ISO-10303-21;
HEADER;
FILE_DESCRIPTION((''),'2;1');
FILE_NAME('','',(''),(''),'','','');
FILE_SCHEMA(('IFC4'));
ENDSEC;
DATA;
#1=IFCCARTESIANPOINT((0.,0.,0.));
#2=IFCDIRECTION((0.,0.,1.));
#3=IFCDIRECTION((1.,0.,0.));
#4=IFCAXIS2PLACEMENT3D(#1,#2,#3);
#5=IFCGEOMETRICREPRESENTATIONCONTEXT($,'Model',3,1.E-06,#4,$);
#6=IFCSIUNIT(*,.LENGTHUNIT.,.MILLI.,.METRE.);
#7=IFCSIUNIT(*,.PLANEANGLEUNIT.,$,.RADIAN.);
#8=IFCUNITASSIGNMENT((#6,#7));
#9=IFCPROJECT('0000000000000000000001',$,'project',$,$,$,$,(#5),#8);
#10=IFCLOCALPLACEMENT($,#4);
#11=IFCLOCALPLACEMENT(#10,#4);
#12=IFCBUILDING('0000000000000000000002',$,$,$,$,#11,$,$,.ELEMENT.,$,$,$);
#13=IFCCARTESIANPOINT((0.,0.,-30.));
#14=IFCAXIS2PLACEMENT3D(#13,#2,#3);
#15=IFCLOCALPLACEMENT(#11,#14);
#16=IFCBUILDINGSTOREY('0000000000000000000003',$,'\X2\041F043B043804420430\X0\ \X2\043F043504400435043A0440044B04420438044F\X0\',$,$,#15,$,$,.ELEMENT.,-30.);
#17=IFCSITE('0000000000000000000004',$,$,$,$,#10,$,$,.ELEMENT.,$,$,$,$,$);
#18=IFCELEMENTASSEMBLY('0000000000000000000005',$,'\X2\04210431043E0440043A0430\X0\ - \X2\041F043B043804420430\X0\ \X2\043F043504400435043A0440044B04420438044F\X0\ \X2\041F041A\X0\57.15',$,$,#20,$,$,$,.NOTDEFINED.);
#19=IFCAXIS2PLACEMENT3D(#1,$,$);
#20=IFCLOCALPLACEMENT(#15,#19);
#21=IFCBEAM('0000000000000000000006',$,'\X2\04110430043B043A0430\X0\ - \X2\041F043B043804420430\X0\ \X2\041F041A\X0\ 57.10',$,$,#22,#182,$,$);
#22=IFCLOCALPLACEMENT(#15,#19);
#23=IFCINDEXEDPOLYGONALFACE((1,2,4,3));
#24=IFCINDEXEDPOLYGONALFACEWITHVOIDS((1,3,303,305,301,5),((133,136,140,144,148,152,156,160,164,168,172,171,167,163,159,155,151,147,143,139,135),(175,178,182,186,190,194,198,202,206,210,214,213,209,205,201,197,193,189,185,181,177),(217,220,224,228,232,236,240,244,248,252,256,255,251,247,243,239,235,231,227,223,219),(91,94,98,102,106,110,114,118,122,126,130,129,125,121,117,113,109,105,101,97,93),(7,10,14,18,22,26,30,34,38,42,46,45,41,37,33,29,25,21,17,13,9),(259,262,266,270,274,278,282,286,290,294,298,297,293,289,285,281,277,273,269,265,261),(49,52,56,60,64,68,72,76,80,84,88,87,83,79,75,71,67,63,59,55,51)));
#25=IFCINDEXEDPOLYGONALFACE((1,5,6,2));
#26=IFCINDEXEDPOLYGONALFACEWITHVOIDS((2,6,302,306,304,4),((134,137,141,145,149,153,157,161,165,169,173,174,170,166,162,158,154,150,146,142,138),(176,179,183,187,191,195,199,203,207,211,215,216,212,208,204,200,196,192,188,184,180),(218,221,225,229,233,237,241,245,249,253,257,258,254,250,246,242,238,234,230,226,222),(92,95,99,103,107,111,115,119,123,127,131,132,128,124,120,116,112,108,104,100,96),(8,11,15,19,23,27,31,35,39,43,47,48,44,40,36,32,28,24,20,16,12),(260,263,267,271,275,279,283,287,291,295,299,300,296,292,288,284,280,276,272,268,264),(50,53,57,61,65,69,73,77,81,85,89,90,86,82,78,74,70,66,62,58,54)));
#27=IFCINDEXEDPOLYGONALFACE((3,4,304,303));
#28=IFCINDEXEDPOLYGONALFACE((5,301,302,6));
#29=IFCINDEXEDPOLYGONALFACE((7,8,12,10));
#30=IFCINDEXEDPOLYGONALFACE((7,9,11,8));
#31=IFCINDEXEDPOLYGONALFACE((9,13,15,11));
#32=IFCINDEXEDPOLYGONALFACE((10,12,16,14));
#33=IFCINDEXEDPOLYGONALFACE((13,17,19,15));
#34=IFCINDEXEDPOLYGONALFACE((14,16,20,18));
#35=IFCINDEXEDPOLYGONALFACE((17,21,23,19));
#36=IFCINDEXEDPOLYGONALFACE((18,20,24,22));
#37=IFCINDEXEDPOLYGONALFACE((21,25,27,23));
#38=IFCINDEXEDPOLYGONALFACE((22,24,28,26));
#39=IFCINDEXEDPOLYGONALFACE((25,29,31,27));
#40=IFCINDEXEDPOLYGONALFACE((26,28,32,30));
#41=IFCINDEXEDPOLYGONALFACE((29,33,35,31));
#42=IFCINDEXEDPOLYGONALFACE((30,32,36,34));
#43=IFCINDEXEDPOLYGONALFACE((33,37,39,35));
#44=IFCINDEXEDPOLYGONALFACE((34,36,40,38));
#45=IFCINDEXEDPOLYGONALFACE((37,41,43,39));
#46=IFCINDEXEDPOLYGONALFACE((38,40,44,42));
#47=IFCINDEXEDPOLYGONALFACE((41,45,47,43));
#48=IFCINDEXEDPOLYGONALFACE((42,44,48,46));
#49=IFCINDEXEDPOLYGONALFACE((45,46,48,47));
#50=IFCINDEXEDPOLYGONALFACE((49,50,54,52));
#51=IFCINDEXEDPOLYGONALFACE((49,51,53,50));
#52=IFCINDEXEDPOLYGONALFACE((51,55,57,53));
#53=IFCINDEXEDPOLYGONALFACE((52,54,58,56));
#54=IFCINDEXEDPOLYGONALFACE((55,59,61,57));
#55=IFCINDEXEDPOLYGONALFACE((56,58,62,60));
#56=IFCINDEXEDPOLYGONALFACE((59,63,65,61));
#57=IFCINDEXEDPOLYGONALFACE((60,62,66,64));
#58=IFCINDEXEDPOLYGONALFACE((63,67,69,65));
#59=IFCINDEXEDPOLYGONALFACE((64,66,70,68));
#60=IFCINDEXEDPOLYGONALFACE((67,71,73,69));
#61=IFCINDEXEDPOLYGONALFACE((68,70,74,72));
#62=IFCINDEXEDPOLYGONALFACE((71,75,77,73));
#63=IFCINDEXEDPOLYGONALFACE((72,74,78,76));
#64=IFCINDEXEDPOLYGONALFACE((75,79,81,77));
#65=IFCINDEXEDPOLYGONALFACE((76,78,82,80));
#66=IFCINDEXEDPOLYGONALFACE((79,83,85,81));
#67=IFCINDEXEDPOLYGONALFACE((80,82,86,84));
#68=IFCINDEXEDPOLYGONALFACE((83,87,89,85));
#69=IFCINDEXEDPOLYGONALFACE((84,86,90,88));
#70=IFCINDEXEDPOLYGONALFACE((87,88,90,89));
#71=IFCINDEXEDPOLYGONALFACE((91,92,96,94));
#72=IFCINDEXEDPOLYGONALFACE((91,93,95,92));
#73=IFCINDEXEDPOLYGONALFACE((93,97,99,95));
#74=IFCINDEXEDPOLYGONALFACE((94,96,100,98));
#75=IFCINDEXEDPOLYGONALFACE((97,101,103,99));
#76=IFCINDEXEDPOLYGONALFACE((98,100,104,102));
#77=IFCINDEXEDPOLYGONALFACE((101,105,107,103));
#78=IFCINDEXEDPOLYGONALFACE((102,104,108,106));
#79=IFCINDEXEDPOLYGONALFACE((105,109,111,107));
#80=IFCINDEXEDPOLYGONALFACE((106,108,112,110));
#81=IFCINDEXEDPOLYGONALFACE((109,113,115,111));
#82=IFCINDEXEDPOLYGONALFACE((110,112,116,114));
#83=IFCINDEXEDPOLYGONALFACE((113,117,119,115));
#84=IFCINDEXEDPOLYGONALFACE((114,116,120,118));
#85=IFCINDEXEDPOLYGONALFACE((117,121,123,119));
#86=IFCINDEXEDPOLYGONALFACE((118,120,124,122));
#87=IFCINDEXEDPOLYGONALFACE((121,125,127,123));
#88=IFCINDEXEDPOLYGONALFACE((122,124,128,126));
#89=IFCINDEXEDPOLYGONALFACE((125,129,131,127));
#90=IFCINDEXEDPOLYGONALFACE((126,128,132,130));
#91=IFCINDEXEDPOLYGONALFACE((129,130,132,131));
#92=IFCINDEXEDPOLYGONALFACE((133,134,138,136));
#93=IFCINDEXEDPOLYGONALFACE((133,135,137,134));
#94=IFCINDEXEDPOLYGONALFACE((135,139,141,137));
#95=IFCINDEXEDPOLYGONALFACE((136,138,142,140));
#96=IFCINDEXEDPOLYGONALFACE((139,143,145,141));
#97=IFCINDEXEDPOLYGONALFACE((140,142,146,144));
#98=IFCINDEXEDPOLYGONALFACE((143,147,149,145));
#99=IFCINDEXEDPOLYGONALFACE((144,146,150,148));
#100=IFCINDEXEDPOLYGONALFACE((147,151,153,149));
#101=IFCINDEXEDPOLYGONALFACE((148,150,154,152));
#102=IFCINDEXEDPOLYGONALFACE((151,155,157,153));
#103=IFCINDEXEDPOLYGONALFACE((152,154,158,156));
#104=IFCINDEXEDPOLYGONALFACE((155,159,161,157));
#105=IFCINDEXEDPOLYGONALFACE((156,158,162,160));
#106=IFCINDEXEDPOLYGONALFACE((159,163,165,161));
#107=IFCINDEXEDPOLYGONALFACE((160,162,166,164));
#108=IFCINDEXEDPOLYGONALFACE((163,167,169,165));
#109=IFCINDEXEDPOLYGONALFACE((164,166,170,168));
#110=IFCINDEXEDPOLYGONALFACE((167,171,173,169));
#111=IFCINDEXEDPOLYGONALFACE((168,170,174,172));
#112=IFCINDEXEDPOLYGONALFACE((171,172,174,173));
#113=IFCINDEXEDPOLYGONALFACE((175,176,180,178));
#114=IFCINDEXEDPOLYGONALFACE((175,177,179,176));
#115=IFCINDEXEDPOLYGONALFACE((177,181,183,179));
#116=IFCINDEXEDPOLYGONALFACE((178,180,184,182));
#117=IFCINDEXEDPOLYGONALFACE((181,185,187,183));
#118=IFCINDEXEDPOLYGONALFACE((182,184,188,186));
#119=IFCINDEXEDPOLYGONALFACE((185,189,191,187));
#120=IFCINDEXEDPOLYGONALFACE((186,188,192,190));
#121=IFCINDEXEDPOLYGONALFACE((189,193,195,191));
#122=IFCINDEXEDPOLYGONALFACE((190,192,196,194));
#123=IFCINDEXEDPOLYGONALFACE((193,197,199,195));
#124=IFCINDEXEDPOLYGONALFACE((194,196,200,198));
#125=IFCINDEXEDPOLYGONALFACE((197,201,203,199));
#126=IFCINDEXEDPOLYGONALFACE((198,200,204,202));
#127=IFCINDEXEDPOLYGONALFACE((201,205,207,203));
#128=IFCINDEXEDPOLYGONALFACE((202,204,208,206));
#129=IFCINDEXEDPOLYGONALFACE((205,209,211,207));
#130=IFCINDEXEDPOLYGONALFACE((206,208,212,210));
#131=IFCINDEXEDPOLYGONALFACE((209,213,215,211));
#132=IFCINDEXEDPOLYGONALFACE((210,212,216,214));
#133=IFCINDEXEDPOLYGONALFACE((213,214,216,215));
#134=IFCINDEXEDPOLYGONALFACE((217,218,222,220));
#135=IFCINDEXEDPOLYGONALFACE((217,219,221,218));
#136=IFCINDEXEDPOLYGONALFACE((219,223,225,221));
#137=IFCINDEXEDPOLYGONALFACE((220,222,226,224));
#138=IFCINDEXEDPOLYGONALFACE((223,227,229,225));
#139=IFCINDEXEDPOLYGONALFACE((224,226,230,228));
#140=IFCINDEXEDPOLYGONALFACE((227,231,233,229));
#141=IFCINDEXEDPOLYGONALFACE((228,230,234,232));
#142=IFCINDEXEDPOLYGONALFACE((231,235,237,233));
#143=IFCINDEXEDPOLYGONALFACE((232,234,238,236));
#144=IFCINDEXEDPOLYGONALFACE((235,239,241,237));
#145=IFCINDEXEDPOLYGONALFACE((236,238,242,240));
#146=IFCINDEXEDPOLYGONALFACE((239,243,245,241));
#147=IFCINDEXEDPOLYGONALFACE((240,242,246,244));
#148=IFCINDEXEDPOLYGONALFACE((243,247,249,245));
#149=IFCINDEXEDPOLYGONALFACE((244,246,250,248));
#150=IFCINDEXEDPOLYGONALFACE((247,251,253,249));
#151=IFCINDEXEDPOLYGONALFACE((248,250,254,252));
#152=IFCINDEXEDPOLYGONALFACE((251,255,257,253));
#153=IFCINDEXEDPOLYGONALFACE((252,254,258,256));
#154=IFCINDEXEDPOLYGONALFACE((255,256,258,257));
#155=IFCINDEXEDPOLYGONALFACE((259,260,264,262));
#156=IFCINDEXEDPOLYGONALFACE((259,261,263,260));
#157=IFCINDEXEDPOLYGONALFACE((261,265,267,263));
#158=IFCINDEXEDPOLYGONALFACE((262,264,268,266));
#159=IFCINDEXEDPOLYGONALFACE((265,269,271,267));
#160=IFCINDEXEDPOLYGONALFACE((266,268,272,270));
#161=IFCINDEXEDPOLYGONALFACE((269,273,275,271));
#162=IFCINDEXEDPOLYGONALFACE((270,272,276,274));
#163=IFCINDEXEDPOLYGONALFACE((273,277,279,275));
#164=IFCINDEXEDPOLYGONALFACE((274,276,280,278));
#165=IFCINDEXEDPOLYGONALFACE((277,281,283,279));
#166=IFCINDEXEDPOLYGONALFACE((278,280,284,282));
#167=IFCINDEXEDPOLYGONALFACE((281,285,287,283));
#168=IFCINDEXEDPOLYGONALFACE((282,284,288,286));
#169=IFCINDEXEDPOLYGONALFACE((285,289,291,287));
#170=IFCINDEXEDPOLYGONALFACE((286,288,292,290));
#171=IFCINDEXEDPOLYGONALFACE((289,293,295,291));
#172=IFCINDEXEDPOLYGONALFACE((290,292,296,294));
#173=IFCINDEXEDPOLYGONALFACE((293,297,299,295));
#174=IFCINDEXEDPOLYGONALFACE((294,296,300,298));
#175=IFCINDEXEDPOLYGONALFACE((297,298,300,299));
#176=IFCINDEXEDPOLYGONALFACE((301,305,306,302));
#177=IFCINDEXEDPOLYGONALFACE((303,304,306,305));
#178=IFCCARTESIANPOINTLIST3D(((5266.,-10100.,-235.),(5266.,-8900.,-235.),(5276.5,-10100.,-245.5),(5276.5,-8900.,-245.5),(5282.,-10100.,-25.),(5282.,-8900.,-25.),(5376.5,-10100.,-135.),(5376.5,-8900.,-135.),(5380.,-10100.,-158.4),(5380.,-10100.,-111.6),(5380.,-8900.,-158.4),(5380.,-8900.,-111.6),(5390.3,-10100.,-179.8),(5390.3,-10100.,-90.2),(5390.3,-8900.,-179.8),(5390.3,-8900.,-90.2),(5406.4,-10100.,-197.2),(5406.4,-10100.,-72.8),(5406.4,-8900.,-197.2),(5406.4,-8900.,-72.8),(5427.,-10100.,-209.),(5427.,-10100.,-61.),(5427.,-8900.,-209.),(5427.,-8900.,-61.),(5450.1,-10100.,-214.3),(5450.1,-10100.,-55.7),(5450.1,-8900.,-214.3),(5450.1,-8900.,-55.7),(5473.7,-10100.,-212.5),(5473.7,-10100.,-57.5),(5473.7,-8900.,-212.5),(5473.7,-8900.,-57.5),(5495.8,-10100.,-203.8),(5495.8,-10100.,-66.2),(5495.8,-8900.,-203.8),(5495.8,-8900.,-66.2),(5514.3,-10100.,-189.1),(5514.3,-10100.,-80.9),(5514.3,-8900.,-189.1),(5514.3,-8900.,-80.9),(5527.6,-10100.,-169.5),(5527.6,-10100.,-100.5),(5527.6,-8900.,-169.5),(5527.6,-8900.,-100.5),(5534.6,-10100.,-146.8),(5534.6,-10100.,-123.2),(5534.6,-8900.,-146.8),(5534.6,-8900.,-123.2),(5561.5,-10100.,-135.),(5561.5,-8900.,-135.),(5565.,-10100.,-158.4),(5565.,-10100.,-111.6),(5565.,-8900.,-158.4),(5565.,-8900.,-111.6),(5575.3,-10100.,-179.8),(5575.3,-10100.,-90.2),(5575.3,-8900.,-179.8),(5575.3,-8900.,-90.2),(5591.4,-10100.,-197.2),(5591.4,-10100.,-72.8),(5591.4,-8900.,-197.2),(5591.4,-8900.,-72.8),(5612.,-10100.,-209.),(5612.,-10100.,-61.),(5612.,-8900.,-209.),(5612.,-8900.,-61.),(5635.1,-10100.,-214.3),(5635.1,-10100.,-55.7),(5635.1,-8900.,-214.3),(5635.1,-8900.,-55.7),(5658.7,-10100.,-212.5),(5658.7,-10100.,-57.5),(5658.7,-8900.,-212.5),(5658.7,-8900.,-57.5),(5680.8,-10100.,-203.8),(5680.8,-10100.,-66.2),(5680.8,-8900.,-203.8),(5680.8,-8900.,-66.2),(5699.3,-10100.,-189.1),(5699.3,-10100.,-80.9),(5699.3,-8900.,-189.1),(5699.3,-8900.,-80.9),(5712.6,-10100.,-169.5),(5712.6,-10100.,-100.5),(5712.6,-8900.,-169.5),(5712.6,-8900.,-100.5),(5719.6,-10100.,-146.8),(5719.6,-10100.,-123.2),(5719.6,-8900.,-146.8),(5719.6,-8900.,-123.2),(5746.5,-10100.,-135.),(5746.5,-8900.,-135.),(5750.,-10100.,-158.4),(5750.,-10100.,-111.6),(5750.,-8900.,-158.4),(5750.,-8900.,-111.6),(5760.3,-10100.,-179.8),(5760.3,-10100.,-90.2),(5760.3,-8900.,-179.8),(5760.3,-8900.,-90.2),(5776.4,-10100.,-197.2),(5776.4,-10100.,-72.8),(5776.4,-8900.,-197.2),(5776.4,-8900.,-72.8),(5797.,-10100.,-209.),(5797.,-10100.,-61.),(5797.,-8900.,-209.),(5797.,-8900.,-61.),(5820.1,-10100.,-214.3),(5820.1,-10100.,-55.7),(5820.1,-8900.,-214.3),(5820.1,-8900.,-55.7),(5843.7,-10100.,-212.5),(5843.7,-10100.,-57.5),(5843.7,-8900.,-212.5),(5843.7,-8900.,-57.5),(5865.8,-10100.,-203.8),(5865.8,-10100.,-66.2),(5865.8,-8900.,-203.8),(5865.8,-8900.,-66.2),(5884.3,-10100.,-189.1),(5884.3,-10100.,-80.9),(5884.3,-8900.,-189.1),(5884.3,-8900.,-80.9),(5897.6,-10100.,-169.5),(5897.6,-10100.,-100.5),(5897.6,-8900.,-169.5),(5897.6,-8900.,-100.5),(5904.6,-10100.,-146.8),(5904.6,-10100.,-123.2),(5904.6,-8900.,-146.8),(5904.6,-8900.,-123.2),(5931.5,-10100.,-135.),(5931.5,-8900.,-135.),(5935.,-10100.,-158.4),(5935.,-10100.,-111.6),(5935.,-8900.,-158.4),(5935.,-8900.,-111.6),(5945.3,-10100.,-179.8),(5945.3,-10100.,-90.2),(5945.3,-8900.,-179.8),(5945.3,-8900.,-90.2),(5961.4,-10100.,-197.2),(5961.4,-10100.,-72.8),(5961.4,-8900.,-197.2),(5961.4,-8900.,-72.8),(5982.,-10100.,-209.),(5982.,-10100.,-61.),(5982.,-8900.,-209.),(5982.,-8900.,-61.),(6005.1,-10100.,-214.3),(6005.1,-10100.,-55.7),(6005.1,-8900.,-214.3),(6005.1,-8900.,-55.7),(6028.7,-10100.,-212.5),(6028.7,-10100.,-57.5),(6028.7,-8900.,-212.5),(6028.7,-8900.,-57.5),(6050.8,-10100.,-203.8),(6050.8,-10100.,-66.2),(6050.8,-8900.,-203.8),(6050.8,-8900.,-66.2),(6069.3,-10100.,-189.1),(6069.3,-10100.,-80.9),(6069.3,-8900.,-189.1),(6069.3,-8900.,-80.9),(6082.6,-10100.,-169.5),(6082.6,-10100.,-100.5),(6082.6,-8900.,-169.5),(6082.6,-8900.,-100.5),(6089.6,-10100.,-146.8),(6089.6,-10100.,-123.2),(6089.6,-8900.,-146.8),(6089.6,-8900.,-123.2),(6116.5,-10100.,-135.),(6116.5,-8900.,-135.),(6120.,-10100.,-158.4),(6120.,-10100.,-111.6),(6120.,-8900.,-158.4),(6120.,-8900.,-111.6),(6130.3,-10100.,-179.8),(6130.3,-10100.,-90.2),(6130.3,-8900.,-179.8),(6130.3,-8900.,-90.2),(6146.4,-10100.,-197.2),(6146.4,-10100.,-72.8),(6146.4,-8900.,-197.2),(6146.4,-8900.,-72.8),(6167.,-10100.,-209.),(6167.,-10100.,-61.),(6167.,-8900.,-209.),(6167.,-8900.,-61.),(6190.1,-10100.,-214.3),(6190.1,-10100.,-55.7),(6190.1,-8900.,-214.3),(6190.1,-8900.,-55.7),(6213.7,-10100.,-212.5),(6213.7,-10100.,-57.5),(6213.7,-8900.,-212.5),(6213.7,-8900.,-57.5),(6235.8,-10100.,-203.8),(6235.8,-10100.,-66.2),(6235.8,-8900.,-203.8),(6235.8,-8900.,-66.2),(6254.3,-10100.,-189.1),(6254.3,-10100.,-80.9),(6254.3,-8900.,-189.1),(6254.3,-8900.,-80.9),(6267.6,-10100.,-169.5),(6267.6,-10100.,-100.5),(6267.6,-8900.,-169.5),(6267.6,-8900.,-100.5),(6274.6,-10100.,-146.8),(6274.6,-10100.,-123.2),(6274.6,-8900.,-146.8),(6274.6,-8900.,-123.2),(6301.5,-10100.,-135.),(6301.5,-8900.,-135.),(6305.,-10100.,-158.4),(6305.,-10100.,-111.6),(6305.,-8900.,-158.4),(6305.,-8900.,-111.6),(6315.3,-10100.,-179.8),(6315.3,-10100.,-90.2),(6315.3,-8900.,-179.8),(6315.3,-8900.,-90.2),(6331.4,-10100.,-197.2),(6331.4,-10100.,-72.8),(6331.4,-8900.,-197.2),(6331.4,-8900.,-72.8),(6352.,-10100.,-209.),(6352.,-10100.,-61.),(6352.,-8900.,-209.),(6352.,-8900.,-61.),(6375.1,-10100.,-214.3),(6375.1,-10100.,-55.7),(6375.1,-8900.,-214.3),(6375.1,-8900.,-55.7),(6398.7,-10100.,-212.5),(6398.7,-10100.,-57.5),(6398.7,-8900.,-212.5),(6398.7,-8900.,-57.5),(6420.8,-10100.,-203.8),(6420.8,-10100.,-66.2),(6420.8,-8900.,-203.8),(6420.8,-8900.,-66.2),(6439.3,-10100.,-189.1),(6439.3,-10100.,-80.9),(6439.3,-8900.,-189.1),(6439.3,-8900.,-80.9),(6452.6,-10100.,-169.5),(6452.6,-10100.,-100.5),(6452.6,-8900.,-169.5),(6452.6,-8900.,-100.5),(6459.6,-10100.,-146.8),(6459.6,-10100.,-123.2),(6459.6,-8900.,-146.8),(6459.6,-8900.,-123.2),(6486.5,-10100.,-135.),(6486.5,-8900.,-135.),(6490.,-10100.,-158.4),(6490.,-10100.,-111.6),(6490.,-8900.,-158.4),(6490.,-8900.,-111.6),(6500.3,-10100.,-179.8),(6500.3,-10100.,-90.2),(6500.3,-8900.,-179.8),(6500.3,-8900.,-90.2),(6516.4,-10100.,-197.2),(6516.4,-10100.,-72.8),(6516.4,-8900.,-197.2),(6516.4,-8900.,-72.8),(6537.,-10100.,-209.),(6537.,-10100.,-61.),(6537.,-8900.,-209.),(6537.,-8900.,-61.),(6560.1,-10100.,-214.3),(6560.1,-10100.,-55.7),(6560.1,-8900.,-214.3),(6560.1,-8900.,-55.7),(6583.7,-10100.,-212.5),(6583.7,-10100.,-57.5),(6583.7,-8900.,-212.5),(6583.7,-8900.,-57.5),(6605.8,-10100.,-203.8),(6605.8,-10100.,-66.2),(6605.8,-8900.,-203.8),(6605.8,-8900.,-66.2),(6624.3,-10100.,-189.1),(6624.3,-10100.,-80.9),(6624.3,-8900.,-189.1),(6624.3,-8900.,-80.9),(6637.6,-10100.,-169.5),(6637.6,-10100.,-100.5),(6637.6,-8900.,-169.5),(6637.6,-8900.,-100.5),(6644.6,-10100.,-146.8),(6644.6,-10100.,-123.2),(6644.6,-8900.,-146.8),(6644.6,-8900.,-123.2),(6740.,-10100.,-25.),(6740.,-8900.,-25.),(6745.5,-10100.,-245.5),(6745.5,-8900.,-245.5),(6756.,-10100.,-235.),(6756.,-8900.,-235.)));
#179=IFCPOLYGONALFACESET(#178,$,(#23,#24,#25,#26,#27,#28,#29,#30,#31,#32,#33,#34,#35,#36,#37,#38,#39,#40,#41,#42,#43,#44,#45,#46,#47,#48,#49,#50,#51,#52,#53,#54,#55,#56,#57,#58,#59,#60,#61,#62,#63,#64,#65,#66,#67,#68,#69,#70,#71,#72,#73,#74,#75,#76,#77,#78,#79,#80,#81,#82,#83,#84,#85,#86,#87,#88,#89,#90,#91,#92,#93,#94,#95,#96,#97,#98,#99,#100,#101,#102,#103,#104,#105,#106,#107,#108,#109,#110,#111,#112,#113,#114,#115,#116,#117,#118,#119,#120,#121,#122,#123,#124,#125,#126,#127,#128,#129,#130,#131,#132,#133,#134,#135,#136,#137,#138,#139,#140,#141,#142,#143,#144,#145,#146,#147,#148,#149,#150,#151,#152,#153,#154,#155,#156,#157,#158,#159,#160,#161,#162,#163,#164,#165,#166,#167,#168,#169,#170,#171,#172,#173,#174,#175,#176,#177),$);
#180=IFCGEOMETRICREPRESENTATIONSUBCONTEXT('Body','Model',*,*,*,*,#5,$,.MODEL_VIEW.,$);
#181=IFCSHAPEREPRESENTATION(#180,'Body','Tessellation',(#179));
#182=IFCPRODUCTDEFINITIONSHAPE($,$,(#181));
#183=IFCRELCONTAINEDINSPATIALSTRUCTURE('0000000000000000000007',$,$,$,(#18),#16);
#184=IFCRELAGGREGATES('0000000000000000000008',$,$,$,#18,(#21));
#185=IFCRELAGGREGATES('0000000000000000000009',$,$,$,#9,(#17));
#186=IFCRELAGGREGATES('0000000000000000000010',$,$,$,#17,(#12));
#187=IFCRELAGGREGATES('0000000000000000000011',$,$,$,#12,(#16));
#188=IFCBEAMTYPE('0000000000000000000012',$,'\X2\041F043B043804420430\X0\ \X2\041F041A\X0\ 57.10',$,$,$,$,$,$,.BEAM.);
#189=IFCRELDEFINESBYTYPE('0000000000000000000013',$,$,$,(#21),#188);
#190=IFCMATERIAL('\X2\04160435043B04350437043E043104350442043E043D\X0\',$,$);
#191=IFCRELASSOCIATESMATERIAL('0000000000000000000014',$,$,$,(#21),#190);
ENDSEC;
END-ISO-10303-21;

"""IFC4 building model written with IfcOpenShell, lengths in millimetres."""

from ifc_helpers import new_model, si_unit, frame, frame_2d, origin_with_axes, place, context, subcontext, project, spatial, line, indexed_curve, circle_curve, outline, extrude, source, transform, mapped, material, type_object, element, aggregate, save


model = new_model("IFC4")

# Units and contexts
model_context = context("Model", 3, precision=1e-06, world=origin_with_axes())
body_context = subcontext(model_context, "Body", "Model", "MODEL_VIEW")
ifc_project = project(units=[si_unit("LENGTHUNIT", "METRE", prefix="MILLI"), si_unit("PLANEANGLEUNIT", "RADIAN")], contexts=[model_context])

# Site, building, storey
site_placement = place(None, origin_with_axes())
site = spatial("IfcSite", under=ifc_project, at=site_placement, CompositionType="ELEMENT")
building_placement = place(site_placement, origin_with_axes())
building = spatial("IfcBuilding", under=site, at=building_placement, CompositionType="ELEMENT")
storey_placement = place(building_placement, frame((0.0, 0.0, -30.0), z_axis=(0.0, 0.0, 1.0), x_axis=(1.0, 0.0, 0.0)))
storey = spatial("IfcBuildingStorey", under=building, at=storey_placement, Name="Плита перекрытия", CompositionType="ELEMENT", Elevation=-30.0)

# Element assembly, beam
assembly_1_placement = place(storey_placement, frame((6011.0, -9650.0, -25.0), z_axis=(0.0, 0.0, 1.0), x_axis=(1.0, 0.0, 0.0)))
assembly_1 = element("IfcElementAssembly", 1, at=assembly_1_placement, inside=storey, Name="Сборка - Плита перекрытия ПК57.15", PredefinedType="NOTDEFINED")
ifc_material_1 = material(Name="Железобетон")
beam_type_1 = type_object("IfcBeamType", Name="Плита ПК 57.10", PredefinedType="BEAM")
shared_shape_1 = source(origin_with_axes(), body_context, "Body", "SweptSolid", [
    extrude(outline(indexed_curve([(-729.0, 0.0), (-745.0, -210.0), (-734.5, -220.5), (734.5, -220.5), (745.0, -210.0), (729.0, 0.0)], segments=[line(1, 2), line(2, 3), line(3, 4), line(4, 5), line(5, 6), line(6, 1)]), holes=[circle_curve(frame_2d((555.0, -110.0), x_axis=(1.0, 0.0)), 79.5), circle_curve(frame_2d((370.0, -110.0), x_axis=(1.0, 0.0)), 79.5), circle_curve(frame_2d((185.0, -110.0), x_axis=(1.0, 0.0)), 79.5), circle_curve(frame_2d((-555.0, -110.0), x_axis=(1.0, 0.0)), 79.5), circle_curve(frame_2d((-370.0, -110.0), x_axis=(1.0, 0.0)), 79.5), circle_curve(frame_2d((-185.0, -110.0), x_axis=(1.0, 0.0)), 79.5), circle_curve(frame_2d((0.0, -110.0), x_axis=(1.0, 0.0)), 79.5)]), origin_with_axes(), (0.0, 0.0, -1.0), 1200.0),
])
beam_1_placement = place(assembly_1_placement, frame((0.0, 750.0, 0.0), z_axis=(0.0, 1.0, 0.0), x_axis=(-1.0, 0.0, 0.0)))
beam_1 = element("IfcBeam", 2, at=beam_1_placement, type_object=beam_type_1, material=ifc_material_1, Name="Балка - Плита ПК 57.10", context=body_context, shape_type="MappedRepresentation", body=[
    mapped(shared_shape_1, transform((0.0, 0.0, 0.0), x_axis=(1.0, 0.0, 0.0), y_axis=(0.0, 1.0, 0.0), z_axis=(0.0, 0.0, 1.0), scale=1.0)),
])
aggregate(assembly_1, [beam_1])

save(model, "model.ifc")
